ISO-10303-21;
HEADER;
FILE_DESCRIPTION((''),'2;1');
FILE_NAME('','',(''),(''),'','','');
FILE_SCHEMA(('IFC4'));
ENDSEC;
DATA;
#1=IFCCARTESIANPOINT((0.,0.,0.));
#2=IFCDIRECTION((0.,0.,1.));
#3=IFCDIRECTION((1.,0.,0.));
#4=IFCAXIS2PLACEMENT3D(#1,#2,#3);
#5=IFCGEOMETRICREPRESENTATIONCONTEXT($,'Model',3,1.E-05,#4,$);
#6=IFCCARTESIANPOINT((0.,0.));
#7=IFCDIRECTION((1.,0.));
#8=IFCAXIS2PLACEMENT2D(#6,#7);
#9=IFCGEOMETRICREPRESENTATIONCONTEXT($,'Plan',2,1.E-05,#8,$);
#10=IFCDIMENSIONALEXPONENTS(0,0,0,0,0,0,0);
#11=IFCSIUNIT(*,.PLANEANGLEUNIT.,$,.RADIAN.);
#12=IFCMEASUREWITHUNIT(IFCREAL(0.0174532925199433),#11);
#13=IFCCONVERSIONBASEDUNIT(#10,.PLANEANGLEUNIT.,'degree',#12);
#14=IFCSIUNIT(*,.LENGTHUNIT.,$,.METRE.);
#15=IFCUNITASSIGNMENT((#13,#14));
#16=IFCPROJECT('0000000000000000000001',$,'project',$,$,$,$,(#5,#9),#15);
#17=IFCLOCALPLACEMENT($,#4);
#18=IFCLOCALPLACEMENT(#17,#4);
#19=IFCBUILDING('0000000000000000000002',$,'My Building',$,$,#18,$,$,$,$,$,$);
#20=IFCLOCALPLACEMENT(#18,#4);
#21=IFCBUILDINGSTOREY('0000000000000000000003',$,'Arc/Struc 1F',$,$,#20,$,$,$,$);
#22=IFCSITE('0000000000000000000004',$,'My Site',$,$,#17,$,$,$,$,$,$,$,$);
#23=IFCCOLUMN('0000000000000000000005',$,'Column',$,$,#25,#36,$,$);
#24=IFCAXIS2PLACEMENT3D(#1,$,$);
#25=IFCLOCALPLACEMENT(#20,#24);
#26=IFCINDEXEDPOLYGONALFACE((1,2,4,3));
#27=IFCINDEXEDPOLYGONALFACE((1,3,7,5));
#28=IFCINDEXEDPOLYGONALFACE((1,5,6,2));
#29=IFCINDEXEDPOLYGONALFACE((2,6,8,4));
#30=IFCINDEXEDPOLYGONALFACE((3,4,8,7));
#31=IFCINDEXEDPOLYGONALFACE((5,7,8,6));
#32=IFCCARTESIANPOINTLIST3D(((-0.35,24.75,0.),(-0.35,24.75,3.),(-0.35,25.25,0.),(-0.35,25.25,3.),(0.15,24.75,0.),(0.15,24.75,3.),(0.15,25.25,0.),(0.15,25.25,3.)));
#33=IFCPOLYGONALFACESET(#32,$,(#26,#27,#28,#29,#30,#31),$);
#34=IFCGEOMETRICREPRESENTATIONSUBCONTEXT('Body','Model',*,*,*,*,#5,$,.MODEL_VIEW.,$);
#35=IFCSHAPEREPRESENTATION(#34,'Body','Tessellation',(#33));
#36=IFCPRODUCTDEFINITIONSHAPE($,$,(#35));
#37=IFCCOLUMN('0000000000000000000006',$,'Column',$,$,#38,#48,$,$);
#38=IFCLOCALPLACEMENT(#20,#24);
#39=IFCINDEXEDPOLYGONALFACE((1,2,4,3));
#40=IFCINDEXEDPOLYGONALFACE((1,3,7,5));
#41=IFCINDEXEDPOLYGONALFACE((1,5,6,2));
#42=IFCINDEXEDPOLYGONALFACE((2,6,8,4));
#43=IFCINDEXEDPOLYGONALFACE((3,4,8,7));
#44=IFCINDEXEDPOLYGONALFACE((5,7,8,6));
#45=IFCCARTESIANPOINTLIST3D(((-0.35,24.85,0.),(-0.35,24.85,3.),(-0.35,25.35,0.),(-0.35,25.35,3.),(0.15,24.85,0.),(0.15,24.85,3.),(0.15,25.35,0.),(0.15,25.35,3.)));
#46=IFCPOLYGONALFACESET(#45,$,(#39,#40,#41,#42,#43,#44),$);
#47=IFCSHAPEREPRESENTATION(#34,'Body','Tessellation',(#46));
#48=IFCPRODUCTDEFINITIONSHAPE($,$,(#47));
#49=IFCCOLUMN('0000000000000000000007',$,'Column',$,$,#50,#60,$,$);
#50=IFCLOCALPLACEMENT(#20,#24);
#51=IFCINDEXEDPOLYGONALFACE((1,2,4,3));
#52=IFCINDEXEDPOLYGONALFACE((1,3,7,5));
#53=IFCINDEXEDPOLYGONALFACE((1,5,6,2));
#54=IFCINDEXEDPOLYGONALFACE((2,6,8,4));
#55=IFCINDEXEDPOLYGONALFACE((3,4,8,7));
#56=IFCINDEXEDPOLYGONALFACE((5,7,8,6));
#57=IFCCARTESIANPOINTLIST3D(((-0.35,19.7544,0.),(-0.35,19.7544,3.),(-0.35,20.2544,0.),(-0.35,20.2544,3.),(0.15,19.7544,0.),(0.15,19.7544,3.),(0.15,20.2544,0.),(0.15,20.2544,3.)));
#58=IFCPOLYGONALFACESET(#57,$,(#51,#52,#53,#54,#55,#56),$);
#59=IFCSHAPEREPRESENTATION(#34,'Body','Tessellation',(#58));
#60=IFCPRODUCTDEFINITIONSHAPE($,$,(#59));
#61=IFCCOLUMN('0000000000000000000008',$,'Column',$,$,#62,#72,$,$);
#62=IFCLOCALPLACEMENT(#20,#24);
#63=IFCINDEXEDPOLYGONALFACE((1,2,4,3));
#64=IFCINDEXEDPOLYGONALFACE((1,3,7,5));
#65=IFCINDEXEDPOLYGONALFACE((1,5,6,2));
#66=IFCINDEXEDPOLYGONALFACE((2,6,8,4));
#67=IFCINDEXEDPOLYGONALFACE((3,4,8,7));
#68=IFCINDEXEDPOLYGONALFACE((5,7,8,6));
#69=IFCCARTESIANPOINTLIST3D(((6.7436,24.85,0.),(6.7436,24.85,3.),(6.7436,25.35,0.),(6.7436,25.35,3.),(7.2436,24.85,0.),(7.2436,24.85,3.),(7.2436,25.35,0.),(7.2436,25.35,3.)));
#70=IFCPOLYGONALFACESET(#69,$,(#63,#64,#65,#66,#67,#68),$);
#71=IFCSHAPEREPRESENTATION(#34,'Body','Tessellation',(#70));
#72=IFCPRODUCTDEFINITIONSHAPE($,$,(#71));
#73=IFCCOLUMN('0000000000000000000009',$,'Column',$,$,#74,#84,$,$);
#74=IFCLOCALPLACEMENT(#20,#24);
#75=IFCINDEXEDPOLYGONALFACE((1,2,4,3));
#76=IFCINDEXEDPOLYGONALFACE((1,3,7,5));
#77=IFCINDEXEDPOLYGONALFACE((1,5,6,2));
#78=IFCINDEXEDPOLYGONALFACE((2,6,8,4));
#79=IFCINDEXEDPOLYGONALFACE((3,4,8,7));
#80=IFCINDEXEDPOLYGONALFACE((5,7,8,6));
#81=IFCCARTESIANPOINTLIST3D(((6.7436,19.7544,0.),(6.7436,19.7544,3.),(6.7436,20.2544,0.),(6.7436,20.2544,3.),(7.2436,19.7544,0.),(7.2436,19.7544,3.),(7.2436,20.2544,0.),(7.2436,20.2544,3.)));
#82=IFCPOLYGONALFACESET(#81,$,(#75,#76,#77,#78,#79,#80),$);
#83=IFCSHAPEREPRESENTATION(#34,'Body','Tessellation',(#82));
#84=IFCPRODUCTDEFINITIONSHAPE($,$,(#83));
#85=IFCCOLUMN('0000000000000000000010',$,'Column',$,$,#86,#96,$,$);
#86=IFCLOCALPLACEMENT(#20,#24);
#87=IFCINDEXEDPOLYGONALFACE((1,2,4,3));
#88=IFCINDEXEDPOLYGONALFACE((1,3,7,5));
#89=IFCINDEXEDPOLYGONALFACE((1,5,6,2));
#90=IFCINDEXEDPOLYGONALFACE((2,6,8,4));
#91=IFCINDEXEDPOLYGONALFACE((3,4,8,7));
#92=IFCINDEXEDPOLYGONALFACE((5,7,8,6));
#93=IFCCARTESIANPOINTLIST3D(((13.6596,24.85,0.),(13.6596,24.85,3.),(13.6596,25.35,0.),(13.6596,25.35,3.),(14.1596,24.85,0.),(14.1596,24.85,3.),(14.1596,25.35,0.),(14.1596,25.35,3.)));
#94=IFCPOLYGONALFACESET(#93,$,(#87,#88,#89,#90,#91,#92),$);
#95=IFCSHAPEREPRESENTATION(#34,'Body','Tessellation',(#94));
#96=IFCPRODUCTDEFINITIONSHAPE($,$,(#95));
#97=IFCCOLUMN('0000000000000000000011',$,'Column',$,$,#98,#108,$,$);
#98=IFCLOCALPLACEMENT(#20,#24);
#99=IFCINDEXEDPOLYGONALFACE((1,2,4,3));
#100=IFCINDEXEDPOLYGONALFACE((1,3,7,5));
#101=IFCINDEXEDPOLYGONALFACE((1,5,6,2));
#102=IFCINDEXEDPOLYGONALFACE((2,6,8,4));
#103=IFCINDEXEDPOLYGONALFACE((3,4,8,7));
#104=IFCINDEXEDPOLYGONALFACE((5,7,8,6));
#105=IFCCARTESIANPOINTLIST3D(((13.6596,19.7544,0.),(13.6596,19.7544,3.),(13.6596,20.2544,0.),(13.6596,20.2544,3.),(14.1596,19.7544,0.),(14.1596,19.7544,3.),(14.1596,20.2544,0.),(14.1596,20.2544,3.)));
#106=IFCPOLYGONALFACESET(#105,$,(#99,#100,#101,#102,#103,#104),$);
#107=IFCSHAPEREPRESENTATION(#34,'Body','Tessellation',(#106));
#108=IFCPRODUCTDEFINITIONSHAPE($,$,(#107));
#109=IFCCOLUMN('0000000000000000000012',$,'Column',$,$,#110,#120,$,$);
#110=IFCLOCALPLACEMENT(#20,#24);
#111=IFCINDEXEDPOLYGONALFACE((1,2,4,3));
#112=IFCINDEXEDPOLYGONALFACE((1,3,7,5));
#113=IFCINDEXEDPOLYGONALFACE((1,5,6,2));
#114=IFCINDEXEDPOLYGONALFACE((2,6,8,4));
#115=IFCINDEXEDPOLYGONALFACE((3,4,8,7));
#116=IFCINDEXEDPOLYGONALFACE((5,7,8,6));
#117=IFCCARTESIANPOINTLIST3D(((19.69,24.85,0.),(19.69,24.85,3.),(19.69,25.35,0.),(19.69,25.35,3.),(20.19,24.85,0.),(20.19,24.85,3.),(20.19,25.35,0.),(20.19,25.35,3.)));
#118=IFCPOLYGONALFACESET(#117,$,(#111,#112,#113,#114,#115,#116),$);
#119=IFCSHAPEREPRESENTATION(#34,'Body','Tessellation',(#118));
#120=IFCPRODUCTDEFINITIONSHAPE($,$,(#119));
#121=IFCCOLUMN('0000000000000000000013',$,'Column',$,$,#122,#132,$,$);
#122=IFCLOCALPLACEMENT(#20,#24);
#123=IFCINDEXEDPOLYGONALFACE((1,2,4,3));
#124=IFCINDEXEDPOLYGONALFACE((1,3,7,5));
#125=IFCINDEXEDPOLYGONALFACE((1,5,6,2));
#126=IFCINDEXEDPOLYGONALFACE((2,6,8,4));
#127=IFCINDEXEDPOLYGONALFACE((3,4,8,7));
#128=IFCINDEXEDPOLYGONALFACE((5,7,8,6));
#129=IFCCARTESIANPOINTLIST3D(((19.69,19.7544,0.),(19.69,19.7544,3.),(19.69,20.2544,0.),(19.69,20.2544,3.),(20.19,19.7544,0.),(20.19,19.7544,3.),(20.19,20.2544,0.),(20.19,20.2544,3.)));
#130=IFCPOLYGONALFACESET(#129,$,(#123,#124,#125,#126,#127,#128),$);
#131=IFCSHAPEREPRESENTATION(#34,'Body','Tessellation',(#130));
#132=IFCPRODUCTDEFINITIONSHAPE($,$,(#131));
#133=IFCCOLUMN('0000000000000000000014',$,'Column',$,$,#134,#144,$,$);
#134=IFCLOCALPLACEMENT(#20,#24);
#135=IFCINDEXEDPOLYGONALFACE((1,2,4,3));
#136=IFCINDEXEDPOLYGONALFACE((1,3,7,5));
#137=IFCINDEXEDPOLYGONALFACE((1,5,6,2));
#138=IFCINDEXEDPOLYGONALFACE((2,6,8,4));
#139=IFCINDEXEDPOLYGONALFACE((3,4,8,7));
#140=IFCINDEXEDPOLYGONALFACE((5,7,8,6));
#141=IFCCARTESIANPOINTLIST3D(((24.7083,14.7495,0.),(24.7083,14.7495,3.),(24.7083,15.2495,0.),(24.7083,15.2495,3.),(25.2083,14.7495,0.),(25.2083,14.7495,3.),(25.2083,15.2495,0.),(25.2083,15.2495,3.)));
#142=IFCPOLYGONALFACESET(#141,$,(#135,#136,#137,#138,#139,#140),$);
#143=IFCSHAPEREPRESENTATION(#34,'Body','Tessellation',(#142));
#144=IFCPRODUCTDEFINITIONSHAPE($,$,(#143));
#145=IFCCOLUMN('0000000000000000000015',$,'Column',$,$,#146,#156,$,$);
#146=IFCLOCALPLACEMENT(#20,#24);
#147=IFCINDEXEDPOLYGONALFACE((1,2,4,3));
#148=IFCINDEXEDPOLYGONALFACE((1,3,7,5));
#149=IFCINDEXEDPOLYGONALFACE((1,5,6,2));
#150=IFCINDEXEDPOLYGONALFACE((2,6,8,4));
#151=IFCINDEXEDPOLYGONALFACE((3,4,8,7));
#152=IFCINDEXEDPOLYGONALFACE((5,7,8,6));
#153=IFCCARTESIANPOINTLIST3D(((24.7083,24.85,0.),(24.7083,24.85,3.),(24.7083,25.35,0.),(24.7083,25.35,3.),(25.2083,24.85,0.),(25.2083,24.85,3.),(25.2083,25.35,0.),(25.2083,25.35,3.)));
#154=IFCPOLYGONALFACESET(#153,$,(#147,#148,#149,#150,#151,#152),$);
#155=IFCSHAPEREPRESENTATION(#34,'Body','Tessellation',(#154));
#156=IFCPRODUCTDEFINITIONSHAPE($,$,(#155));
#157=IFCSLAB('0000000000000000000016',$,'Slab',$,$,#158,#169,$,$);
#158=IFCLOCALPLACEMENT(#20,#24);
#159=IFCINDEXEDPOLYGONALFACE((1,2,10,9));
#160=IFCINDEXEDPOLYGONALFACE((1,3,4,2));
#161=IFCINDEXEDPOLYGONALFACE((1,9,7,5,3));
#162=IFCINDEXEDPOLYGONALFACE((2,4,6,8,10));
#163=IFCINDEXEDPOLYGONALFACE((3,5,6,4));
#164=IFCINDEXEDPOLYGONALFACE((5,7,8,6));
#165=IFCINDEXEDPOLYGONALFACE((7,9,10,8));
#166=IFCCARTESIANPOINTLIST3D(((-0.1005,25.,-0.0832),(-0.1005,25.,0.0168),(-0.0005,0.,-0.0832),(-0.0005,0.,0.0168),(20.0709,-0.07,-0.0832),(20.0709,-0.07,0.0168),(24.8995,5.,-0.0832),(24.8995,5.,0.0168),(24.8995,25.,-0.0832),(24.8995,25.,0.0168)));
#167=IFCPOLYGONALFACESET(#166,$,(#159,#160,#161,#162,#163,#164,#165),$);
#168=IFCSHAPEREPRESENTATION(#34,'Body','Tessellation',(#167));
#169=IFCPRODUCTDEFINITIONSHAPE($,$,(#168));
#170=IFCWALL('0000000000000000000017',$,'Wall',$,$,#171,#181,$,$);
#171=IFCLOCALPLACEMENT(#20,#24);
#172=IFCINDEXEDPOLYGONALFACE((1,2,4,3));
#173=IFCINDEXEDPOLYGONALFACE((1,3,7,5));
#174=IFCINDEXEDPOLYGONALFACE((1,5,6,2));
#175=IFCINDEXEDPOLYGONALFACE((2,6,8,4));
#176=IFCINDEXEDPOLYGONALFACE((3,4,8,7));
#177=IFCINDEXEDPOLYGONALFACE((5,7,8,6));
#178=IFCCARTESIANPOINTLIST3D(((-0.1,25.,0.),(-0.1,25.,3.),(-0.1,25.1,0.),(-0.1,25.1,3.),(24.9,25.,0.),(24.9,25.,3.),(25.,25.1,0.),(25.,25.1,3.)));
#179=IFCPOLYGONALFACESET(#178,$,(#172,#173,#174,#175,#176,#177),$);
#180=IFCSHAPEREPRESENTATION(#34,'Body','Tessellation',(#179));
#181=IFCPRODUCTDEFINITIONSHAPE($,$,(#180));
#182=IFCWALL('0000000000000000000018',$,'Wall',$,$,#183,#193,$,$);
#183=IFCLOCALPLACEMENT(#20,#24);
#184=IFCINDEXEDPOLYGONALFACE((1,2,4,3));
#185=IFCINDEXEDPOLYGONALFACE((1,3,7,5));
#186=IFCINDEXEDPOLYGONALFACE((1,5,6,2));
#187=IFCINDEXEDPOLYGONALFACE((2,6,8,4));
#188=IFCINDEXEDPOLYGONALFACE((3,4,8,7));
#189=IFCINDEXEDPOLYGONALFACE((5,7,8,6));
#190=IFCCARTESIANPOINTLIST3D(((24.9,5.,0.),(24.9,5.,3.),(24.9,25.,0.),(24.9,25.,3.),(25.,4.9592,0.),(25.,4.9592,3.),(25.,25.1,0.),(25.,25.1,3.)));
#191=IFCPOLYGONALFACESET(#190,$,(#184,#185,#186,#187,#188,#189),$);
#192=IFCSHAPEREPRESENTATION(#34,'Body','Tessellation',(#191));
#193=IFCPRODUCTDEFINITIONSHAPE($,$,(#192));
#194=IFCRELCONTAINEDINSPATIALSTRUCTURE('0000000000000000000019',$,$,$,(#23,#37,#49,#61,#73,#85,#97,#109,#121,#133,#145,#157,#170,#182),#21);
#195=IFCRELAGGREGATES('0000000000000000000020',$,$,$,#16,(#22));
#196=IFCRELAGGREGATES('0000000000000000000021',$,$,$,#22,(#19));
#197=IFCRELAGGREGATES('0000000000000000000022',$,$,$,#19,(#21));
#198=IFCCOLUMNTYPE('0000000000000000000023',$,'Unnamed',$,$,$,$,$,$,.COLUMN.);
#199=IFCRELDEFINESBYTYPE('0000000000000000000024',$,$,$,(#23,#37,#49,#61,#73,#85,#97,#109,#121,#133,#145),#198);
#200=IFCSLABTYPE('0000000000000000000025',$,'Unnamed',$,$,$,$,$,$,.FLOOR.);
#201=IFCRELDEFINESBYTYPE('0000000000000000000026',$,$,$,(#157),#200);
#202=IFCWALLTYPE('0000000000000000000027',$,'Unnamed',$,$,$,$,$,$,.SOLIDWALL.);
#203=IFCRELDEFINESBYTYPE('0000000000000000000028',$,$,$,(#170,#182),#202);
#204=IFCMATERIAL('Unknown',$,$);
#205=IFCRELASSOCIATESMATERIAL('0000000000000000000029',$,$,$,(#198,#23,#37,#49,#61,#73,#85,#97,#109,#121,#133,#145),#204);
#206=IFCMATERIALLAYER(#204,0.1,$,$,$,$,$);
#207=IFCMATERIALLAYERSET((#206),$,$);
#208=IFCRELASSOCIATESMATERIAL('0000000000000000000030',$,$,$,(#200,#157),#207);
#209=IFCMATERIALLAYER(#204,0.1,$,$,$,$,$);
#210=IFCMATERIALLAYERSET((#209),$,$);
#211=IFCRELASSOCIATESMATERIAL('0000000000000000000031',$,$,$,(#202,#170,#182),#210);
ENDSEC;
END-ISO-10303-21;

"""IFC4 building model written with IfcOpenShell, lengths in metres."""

from ifc_helpers import new_model, entity, si_unit, converted_unit, frame, origin_with_axes, origin_2d_with_axis, place, context, subcontext, project, spatial, line, indexed_curve, rectangle, outline, extrude, material, layer, layer_set, layer_usage, material_profile, profile_set, profile_usage, type_object, element, save


model = new_model("IFC4")

# Units and contexts
model_context = context("Model", 3, precision=1e-05, world=origin_with_axes())
plan_context = context("Plan", 2, precision=1e-05, world=origin_2d_with_axis())
body_context_1 = subcontext(model_context, "Body", "Model", "MODEL_VIEW")
ifc_project = project(units=[converted_unit("PLANEANGLEUNIT", "degree", entity("IfcReal", 0.0174532925199433), si_unit("PLANEANGLEUNIT", "RADIAN"), dimensions=[0, 0, 0, 0, 0, 0, 0]), si_unit("LENGTHUNIT", "METRE")], contexts=[model_context, plan_context])

# Site, building, storey
site_placement = place(None, origin_with_axes())
site = spatial("IfcSite", under=ifc_project, at=site_placement, Name="My Site")
building_placement = place(site_placement, origin_with_axes())
building = spatial("IfcBuilding", under=site, at=building_placement, Name="My Building")
storey_placement = place(building_placement, origin_with_axes())
storey = spatial("IfcBuildingStorey", under=building, at=storey_placement, Name="Arc/Struc 1F")

# Columns
ifc_material = material(Name="Unknown")
ifc_material_profile = material_profile(ifc_material, rectangle(XDim=0.5, YDim=0.5))
ifc_profile_set = profile_set([ifc_material_profile])
ifc_profile_usage_1 = profile_usage(ifc_profile_set, cardinal=5)
column_type = type_object("IfcColumnType", Name="Unnamed", PredefinedType="COLUMN", material=ifc_profile_set)
column_1_placement = place(storey_placement, frame((-0.1, 25.0, 0.0), z_axis=(0.0, 0.0, 1.0), x_axis=(1.0, 0.0, 0.0)))
element("IfcColumn", 1, at=column_1_placement, inside=storey, type_object=column_type, material=ifc_profile_usage_1, Name="Column", context=body_context_1, shape_type="SweptSolid", body=[
    extrude(rectangle(XDim=0.5, YDim=0.5), origin_with_axes(), (0.0, 0.0, 1.0), 3.0),
])
ifc_profile_usage_2 = profile_usage(ifc_profile_set, cardinal=5)
column_2_placement = place(storey_placement, frame((-0.1, 25.1, 0.0), z_axis=(0.0, 0.0, 1.0), x_axis=(1.0, 0.0, 0.0)))
element("IfcColumn", 2, at=column_2_placement, inside=storey, type_object=column_type, material=ifc_profile_usage_2, Name="Column", context=body_context_1, shape_type="SweptSolid", body=[
    extrude(rectangle(XDim=0.5, YDim=0.5), origin_with_axes(), (0.0, 0.0, 1.0), 3.0),
])
ifc_profile_usage_3 = profile_usage(ifc_profile_set, cardinal=5)
column_3_placement = place(storey_placement, frame((-0.1, 20.0044, 0.0), z_axis=(0.0, 0.0, 1.0), x_axis=(1.0, 0.0, 0.0)))
element("IfcColumn", 3, at=column_3_placement, inside=storey, type_object=column_type, material=ifc_profile_usage_3, Name="Column", context=body_context_1, shape_type="SweptSolid", body=[
    extrude(rectangle(XDim=0.5, YDim=0.5), origin_with_axes(), (0.0, 0.0, 1.0), 3.0),
])
ifc_profile_usage_4 = profile_usage(ifc_profile_set, cardinal=5)
column_4_placement = place(storey_placement, frame((6.9936, 25.1, 0.0), z_axis=(0.0, 0.0, 1.0), x_axis=(1.0, 0.0, 0.0)))
element("IfcColumn", 4, at=column_4_placement, inside=storey, type_object=column_type, material=ifc_profile_usage_4, Name="Column", context=body_context_1, shape_type="SweptSolid", body=[
    extrude(rectangle(XDim=0.5, YDim=0.5), origin_with_axes(), (0.0, 0.0, 1.0), 3.0),
])
ifc_profile_usage_5 = profile_usage(ifc_profile_set, cardinal=5)
column_5_placement = place(storey_placement, frame((6.9936, 20.0044, 0.0), z_axis=(0.0, 0.0, 1.0), x_axis=(1.0, 0.0, 0.0)))
element("IfcColumn", 5, at=column_5_placement, inside=storey, type_object=column_type, material=ifc_profile_usage_5, Name="Column", context=body_context_1, shape_type="SweptSolid", body=[
    extrude(rectangle(XDim=0.5, YDim=0.5), origin_with_axes(), (0.0, 0.0, 1.0), 3.0),
])
ifc_profile_usage_6 = profile_usage(ifc_profile_set, cardinal=5)
column_6_placement = place(storey_placement, frame((13.9096, 25.1, 0.0), z_axis=(0.0, 0.0, 1.0), x_axis=(1.0, 0.0, 0.0)))
element("IfcColumn", 6, at=column_6_placement, inside=storey, type_object=column_type, material=ifc_profile_usage_6, Name="Column", context=body_context_1, shape_type="SweptSolid", body=[
    extrude(rectangle(XDim=0.5, YDim=0.5), origin_with_axes(), (0.0, 0.0, 1.0), 3.0),
])
ifc_profile_usage_7 = profile_usage(ifc_profile_set, cardinal=5)
column_7_placement = place(storey_placement, frame((13.9096, 20.0044, 0.0), z_axis=(0.0, 0.0, 1.0), x_axis=(1.0, 0.0, 0.0)))
element("IfcColumn", 7, at=column_7_placement, inside=storey, type_object=column_type, material=ifc_profile_usage_7, Name="Column", context=body_context_1, shape_type="SweptSolid", body=[
    extrude(rectangle(XDim=0.5, YDim=0.5), origin_with_axes(), (0.0, 0.0, 1.0), 3.0),
])
ifc_profile_usage_8 = profile_usage(ifc_profile_set, cardinal=5)
column_8_placement = place(storey_placement, frame((19.94, 25.1, 0.0), z_axis=(0.0, 0.0, 1.0), x_axis=(1.0, 0.0, 0.0)))
element("IfcColumn", 8, at=column_8_placement, inside=storey, type_object=column_type, material=ifc_profile_usage_8, Name="Column", context=body_context_1, shape_type="SweptSolid", body=[
    extrude(rectangle(XDim=0.5, YDim=0.5), origin_with_axes(), (0.0, 0.0, 1.0), 3.0),
])
ifc_profile_usage_9 = profile_usage(ifc_profile_set, cardinal=5)
column_9_placement = place(storey_placement, frame((19.94, 20.0044, 0.0), z_axis=(0.0, 0.0, 1.0), x_axis=(1.0, 0.0, 0.0)))
element("IfcColumn", 9, at=column_9_placement, inside=storey, type_object=column_type, material=ifc_profile_usage_9, Name="Column", context=body_context_1, shape_type="SweptSolid", body=[
    extrude(rectangle(XDim=0.5, YDim=0.5), origin_with_axes(), (0.0, 0.0, 1.0), 3.0),
])
ifc_profile_usage_10 = profile_usage(ifc_profile_set, cardinal=5)
column_10_placement = place(storey_placement, frame((24.9583, 14.9995, 0.0), z_axis=(0.0, 0.0, 1.0), x_axis=(1.0, 0.0, 0.0)))
element("IfcColumn", 10, at=column_10_placement, inside=storey, type_object=column_type, material=ifc_profile_usage_10, Name="Column", context=body_context_1, shape_type="SweptSolid", body=[
    extrude(rectangle(XDim=0.5, YDim=0.5), origin_with_axes(), (0.0, 0.0, 1.0), 3.0),
])
ifc_profile_usage_11 = profile_usage(ifc_profile_set, cardinal=5)
column_11_placement = place(storey_placement, frame((24.9583, 25.1, 0.0), z_axis=(0.0, 0.0, 1.0), x_axis=(1.0, 0.0, 0.0)))
element("IfcColumn", 11, at=column_11_placement, inside=storey, type_object=column_type, material=ifc_profile_usage_11, Name="Column", context=body_context_1, shape_type="SweptSolid", body=[
    extrude(rectangle(XDim=0.5, YDim=0.5), origin_with_axes(), (0.0, 0.0, 1.0), 3.0),
])

# Slab
ifc_layer_1 = layer(ifc_material, 0.1)
ifc_layer_set_1 = layer_set([ifc_layer_1])
ifc_layer_usage_1 = layer_usage(ifc_layer_set_1, "AXIS3", "POSITIVE", -0.1)
slab_type = type_object("IfcSlabType", Name="Unnamed", PredefinedType="FLOOR", material=ifc_layer_set_1)
slab_placement = place(storey_placement, frame((-0.1005, 25.0, 0.0168), z_axis=(0.0, 0.0, 1.0), x_axis=(1.0, 0.0, 0.0)))
element("IfcSlab", 12, at=slab_placement, inside=storey, type_object=slab_type, material=ifc_layer_usage_1, Name="Slab", context=body_context_1, shape_type="SweptSolid", body=[
    extrude(outline(indexed_curve([(0.0, 0.0), (25.0, 0.0), (25.0, -20.0), (20.1714, -25.07), (0.1, -25.0), (0.0, 0.0)])), frame((0.0, 0.0, -0.1), z_axis=(0.0, 0.0, 1.0), x_axis=(1.0, 0.0, 0.0)), (0.0, 0.0, 1.0), 0.1),
])

# Walls
ifc_layer_2 = layer(ifc_material, 0.1)
ifc_layer_set_2 = layer_set([ifc_layer_2])
ifc_layer_usage_2 = layer_usage(ifc_layer_set_2, "AXIS2", "POSITIVE", 0.0)
wall_type = type_object("IfcWallType", Name="Unnamed", PredefinedType="SOLIDWALL", material=ifc_layer_set_2)
wall_1_placement = place(storey_placement, frame((-0.1, 25.0, 0.0), z_axis=(0.0, 0.0, 1.0), x_axis=(1.0, 0.0, 0.0)))
element("IfcWall", 13, at=wall_1_placement, inside=storey, type_object=wall_type, material=ifc_layer_usage_2, Name="Wall", context=body_context_1, shape_type="SweptSolid", body=[
    extrude(outline(indexed_curve([(0.0, 0.0), (0.0, 0.1), (25.1, 0.1), (25.0, 0.0)], segments=[line(1, 2, 3, 4, 1)])), origin_with_axes(), (0.0, 0.0, 1.0), 3.0),
])
ifc_layer_usage_3 = layer_usage(ifc_layer_set_2, "AXIS2", "POSITIVE", 0.0)
wall_2_placement = place(storey_placement, frame((24.9, 25.0, 0.0), z_axis=(0.0, 0.0, 1.0), x_axis=(0.0, -1.0, 0.0)))
element("IfcWall", 14, at=wall_2_placement, inside=storey, type_object=wall_type, material=ifc_layer_usage_3, Name="Wall", context=body_context_1, shape_type="SweptSolid", body=[
    extrude(outline(indexed_curve([(0.0, 0.0), (-0.1, 0.1), (20.0408, 0.1), (20.0, 0.0)], segments=[line(1, 2, 3, 4, 1)])), origin_with_axes(), (0.0, 0.0, 1.0), 3.0),
])

save(model, "model.ifc")
